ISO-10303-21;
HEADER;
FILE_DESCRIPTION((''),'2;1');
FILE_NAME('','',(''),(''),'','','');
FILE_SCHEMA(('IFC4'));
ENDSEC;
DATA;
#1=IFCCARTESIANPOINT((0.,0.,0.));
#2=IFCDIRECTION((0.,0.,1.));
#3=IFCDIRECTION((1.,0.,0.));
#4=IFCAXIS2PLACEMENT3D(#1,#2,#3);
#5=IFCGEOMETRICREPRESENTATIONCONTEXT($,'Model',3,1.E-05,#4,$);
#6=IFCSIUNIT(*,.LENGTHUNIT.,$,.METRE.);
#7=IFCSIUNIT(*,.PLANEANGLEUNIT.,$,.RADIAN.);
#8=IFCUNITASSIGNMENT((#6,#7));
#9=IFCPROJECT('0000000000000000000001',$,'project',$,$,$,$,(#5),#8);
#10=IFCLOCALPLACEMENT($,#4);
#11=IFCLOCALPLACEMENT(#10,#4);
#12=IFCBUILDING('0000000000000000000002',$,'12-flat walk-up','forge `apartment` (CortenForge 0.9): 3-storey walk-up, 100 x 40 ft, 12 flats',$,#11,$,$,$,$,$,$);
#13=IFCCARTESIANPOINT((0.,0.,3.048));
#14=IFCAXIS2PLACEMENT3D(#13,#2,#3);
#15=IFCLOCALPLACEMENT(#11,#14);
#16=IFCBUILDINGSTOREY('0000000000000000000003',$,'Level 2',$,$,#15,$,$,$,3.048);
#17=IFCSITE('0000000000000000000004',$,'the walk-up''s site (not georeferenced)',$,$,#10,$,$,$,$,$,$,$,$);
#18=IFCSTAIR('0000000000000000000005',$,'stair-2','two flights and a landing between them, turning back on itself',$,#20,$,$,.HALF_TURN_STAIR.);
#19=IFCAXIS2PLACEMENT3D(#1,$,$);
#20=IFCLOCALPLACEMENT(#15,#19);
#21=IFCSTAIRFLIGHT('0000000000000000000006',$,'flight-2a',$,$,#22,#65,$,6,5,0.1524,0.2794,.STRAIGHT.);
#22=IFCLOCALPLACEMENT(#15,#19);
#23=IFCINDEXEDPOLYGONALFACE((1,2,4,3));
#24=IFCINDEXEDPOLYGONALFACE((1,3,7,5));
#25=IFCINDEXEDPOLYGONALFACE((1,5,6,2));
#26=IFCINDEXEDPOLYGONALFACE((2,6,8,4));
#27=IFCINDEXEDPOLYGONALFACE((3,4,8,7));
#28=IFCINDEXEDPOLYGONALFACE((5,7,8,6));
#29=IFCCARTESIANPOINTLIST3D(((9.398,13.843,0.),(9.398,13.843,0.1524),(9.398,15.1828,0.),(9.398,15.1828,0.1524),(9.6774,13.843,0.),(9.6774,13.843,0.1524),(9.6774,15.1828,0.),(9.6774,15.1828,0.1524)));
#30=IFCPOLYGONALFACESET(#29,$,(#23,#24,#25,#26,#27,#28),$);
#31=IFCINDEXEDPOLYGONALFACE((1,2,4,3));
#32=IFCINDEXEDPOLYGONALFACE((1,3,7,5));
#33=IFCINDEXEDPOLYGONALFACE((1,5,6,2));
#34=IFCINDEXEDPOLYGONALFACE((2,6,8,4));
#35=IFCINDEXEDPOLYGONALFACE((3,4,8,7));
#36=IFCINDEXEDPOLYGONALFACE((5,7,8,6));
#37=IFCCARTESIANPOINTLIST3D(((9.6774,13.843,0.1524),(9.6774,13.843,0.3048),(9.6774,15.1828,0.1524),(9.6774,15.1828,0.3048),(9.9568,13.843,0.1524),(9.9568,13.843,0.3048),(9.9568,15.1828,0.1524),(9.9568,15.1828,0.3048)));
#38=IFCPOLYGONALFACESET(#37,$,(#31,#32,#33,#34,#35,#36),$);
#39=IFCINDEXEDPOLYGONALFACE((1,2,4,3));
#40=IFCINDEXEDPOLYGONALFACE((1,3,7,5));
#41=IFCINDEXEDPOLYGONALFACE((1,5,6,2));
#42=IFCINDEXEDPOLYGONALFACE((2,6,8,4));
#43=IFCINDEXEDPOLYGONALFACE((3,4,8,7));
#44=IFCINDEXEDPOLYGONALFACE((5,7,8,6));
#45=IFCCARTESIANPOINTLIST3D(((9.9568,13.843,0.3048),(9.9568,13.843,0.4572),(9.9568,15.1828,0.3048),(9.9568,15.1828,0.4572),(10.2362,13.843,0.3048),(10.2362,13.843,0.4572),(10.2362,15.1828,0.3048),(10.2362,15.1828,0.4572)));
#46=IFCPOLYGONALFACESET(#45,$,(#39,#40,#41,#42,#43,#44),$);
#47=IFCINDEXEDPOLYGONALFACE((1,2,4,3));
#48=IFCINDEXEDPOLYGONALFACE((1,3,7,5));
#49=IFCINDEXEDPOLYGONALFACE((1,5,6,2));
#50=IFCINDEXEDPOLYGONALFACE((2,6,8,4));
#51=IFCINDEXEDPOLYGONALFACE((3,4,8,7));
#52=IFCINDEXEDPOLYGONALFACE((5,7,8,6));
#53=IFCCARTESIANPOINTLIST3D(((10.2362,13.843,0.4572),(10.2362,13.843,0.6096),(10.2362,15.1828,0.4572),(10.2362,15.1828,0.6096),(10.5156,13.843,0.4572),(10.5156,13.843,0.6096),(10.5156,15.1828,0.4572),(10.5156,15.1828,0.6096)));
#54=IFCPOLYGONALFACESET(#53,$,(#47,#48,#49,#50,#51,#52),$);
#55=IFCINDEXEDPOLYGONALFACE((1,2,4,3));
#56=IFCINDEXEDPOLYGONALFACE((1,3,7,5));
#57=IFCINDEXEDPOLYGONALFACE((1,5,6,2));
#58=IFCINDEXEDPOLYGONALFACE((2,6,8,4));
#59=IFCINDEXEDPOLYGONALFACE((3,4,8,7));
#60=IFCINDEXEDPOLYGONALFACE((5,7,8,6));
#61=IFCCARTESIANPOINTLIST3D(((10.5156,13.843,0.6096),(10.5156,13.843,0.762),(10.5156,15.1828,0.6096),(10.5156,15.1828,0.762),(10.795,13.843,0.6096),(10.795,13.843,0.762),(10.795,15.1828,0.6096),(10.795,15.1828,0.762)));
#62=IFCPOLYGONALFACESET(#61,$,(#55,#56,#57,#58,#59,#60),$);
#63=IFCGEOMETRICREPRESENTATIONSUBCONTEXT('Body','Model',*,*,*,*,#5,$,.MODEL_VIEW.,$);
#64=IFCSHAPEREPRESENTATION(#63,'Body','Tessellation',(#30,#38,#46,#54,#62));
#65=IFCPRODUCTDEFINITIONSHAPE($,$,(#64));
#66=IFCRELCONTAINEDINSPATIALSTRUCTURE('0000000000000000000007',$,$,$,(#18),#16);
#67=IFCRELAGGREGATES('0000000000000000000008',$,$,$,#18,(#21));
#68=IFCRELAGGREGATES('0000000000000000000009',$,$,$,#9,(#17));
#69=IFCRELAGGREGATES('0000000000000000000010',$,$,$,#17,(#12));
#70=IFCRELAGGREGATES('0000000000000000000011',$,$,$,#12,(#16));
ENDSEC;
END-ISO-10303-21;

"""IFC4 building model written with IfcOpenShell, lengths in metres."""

from ifc_helpers import new_model, si_unit, frame, frame_2d, origin, origin_with_axes, place, context, subcontext, project, spatial, rectangle, extrude, element, aggregate, save


model = new_model("IFC4")

# Units and contexts
model_context = context("Model", 3, precision=1e-05, world=origin_with_axes())
body_context = subcontext(model_context, "Body", "Model", "MODEL_VIEW")
ifc_project = project(units=[si_unit("LENGTHUNIT", "METRE"), si_unit("PLANEANGLEUNIT", "RADIAN")], contexts=[model_context])

# Site, building, storey
site_placement = place(None, origin_with_axes())
site = spatial("IfcSite", under=ifc_project, at=site_placement, Name="the walk-up's site (not georeferenced)")
building_placement = place(site_placement, origin_with_axes())
building = spatial("IfcBuilding", under=site, at=building_placement, Name="12-flat walk-up", Description="forge `apartment` (CortenForge 0.9): 3-storey walk-up, 100 x 40 ft, 12 flats")
storey_placement = place(building_placement, frame((0.0, 0.0, 3.048), z_axis=(0.0, 0.0, 1.0), x_axis=(1.0, 0.0, 0.0)))
storey = spatial("IfcBuildingStorey", under=building, at=storey_placement, Name="Level 2", Elevation=3.048)

# Stair
stair_placement = place(storey_placement, frame((0.0, 0.0, -3.048), z_axis=(0.0, 0.0, 1.0), x_axis=(1.0, 0.0, 0.0)))
stair = element("IfcStair", 1, at=stair_placement, inside=storey, Name="stair-2", Description="two flights and a landing between them, turning back on itself", PredefinedType="HALF_TURN_STAIR")

# Stair flight
stair_flight_placement = place(stair_placement, frame((9.398, 13.843, 3.048), z_axis=(0.0, 0.0, 1.0), x_axis=(1.0, 0.0, 0.0)))
stair_flight = element("IfcStairFlight", 2, at=stair_flight_placement, Name="flight-2a", NumberOfRisers=6, NumberOfTreads=5, PredefinedType="STRAIGHT", RiserHeight=0.1524, TreadLength=0.2794, context=body_context, shape_type="SweptSolid", body=[
    extrude(rectangle(XDim=0.2794, YDim=1.3399, at=frame_2d((0.1397, 0.6699))), origin(), (0.0, 0.0, 1.0), 0.1524),
    extrude(rectangle(XDim=0.2794, YDim=1.3399, at=frame_2d((0.1397, 0.6699))), frame((0.2794, 0.0, 0.1524)), (0.0, 0.0, 1.0), 0.1524),
    extrude(rectangle(XDim=0.2794, YDim=1.3399, at=frame_2d((0.1397, 0.6699))), frame((0.5588, 0.0, 0.3048)), (0.0, 0.0, 1.0), 0.1524),
    extrude(rectangle(XDim=0.2794, YDim=1.3399, at=frame_2d((0.1397, 0.6699))), frame((0.8382, 0.0, 0.4572)), (0.0, 0.0, 1.0), 0.1524),
    extrude(rectangle(XDim=0.2794, YDim=1.3399, at=frame_2d((0.1397, 0.6699))), frame((1.1176, 0.0, 0.6096)), (0.0, 0.0, 1.0), 0.1524),
])
aggregate(stair, [stair_flight])

save(model, "model.ifc")
